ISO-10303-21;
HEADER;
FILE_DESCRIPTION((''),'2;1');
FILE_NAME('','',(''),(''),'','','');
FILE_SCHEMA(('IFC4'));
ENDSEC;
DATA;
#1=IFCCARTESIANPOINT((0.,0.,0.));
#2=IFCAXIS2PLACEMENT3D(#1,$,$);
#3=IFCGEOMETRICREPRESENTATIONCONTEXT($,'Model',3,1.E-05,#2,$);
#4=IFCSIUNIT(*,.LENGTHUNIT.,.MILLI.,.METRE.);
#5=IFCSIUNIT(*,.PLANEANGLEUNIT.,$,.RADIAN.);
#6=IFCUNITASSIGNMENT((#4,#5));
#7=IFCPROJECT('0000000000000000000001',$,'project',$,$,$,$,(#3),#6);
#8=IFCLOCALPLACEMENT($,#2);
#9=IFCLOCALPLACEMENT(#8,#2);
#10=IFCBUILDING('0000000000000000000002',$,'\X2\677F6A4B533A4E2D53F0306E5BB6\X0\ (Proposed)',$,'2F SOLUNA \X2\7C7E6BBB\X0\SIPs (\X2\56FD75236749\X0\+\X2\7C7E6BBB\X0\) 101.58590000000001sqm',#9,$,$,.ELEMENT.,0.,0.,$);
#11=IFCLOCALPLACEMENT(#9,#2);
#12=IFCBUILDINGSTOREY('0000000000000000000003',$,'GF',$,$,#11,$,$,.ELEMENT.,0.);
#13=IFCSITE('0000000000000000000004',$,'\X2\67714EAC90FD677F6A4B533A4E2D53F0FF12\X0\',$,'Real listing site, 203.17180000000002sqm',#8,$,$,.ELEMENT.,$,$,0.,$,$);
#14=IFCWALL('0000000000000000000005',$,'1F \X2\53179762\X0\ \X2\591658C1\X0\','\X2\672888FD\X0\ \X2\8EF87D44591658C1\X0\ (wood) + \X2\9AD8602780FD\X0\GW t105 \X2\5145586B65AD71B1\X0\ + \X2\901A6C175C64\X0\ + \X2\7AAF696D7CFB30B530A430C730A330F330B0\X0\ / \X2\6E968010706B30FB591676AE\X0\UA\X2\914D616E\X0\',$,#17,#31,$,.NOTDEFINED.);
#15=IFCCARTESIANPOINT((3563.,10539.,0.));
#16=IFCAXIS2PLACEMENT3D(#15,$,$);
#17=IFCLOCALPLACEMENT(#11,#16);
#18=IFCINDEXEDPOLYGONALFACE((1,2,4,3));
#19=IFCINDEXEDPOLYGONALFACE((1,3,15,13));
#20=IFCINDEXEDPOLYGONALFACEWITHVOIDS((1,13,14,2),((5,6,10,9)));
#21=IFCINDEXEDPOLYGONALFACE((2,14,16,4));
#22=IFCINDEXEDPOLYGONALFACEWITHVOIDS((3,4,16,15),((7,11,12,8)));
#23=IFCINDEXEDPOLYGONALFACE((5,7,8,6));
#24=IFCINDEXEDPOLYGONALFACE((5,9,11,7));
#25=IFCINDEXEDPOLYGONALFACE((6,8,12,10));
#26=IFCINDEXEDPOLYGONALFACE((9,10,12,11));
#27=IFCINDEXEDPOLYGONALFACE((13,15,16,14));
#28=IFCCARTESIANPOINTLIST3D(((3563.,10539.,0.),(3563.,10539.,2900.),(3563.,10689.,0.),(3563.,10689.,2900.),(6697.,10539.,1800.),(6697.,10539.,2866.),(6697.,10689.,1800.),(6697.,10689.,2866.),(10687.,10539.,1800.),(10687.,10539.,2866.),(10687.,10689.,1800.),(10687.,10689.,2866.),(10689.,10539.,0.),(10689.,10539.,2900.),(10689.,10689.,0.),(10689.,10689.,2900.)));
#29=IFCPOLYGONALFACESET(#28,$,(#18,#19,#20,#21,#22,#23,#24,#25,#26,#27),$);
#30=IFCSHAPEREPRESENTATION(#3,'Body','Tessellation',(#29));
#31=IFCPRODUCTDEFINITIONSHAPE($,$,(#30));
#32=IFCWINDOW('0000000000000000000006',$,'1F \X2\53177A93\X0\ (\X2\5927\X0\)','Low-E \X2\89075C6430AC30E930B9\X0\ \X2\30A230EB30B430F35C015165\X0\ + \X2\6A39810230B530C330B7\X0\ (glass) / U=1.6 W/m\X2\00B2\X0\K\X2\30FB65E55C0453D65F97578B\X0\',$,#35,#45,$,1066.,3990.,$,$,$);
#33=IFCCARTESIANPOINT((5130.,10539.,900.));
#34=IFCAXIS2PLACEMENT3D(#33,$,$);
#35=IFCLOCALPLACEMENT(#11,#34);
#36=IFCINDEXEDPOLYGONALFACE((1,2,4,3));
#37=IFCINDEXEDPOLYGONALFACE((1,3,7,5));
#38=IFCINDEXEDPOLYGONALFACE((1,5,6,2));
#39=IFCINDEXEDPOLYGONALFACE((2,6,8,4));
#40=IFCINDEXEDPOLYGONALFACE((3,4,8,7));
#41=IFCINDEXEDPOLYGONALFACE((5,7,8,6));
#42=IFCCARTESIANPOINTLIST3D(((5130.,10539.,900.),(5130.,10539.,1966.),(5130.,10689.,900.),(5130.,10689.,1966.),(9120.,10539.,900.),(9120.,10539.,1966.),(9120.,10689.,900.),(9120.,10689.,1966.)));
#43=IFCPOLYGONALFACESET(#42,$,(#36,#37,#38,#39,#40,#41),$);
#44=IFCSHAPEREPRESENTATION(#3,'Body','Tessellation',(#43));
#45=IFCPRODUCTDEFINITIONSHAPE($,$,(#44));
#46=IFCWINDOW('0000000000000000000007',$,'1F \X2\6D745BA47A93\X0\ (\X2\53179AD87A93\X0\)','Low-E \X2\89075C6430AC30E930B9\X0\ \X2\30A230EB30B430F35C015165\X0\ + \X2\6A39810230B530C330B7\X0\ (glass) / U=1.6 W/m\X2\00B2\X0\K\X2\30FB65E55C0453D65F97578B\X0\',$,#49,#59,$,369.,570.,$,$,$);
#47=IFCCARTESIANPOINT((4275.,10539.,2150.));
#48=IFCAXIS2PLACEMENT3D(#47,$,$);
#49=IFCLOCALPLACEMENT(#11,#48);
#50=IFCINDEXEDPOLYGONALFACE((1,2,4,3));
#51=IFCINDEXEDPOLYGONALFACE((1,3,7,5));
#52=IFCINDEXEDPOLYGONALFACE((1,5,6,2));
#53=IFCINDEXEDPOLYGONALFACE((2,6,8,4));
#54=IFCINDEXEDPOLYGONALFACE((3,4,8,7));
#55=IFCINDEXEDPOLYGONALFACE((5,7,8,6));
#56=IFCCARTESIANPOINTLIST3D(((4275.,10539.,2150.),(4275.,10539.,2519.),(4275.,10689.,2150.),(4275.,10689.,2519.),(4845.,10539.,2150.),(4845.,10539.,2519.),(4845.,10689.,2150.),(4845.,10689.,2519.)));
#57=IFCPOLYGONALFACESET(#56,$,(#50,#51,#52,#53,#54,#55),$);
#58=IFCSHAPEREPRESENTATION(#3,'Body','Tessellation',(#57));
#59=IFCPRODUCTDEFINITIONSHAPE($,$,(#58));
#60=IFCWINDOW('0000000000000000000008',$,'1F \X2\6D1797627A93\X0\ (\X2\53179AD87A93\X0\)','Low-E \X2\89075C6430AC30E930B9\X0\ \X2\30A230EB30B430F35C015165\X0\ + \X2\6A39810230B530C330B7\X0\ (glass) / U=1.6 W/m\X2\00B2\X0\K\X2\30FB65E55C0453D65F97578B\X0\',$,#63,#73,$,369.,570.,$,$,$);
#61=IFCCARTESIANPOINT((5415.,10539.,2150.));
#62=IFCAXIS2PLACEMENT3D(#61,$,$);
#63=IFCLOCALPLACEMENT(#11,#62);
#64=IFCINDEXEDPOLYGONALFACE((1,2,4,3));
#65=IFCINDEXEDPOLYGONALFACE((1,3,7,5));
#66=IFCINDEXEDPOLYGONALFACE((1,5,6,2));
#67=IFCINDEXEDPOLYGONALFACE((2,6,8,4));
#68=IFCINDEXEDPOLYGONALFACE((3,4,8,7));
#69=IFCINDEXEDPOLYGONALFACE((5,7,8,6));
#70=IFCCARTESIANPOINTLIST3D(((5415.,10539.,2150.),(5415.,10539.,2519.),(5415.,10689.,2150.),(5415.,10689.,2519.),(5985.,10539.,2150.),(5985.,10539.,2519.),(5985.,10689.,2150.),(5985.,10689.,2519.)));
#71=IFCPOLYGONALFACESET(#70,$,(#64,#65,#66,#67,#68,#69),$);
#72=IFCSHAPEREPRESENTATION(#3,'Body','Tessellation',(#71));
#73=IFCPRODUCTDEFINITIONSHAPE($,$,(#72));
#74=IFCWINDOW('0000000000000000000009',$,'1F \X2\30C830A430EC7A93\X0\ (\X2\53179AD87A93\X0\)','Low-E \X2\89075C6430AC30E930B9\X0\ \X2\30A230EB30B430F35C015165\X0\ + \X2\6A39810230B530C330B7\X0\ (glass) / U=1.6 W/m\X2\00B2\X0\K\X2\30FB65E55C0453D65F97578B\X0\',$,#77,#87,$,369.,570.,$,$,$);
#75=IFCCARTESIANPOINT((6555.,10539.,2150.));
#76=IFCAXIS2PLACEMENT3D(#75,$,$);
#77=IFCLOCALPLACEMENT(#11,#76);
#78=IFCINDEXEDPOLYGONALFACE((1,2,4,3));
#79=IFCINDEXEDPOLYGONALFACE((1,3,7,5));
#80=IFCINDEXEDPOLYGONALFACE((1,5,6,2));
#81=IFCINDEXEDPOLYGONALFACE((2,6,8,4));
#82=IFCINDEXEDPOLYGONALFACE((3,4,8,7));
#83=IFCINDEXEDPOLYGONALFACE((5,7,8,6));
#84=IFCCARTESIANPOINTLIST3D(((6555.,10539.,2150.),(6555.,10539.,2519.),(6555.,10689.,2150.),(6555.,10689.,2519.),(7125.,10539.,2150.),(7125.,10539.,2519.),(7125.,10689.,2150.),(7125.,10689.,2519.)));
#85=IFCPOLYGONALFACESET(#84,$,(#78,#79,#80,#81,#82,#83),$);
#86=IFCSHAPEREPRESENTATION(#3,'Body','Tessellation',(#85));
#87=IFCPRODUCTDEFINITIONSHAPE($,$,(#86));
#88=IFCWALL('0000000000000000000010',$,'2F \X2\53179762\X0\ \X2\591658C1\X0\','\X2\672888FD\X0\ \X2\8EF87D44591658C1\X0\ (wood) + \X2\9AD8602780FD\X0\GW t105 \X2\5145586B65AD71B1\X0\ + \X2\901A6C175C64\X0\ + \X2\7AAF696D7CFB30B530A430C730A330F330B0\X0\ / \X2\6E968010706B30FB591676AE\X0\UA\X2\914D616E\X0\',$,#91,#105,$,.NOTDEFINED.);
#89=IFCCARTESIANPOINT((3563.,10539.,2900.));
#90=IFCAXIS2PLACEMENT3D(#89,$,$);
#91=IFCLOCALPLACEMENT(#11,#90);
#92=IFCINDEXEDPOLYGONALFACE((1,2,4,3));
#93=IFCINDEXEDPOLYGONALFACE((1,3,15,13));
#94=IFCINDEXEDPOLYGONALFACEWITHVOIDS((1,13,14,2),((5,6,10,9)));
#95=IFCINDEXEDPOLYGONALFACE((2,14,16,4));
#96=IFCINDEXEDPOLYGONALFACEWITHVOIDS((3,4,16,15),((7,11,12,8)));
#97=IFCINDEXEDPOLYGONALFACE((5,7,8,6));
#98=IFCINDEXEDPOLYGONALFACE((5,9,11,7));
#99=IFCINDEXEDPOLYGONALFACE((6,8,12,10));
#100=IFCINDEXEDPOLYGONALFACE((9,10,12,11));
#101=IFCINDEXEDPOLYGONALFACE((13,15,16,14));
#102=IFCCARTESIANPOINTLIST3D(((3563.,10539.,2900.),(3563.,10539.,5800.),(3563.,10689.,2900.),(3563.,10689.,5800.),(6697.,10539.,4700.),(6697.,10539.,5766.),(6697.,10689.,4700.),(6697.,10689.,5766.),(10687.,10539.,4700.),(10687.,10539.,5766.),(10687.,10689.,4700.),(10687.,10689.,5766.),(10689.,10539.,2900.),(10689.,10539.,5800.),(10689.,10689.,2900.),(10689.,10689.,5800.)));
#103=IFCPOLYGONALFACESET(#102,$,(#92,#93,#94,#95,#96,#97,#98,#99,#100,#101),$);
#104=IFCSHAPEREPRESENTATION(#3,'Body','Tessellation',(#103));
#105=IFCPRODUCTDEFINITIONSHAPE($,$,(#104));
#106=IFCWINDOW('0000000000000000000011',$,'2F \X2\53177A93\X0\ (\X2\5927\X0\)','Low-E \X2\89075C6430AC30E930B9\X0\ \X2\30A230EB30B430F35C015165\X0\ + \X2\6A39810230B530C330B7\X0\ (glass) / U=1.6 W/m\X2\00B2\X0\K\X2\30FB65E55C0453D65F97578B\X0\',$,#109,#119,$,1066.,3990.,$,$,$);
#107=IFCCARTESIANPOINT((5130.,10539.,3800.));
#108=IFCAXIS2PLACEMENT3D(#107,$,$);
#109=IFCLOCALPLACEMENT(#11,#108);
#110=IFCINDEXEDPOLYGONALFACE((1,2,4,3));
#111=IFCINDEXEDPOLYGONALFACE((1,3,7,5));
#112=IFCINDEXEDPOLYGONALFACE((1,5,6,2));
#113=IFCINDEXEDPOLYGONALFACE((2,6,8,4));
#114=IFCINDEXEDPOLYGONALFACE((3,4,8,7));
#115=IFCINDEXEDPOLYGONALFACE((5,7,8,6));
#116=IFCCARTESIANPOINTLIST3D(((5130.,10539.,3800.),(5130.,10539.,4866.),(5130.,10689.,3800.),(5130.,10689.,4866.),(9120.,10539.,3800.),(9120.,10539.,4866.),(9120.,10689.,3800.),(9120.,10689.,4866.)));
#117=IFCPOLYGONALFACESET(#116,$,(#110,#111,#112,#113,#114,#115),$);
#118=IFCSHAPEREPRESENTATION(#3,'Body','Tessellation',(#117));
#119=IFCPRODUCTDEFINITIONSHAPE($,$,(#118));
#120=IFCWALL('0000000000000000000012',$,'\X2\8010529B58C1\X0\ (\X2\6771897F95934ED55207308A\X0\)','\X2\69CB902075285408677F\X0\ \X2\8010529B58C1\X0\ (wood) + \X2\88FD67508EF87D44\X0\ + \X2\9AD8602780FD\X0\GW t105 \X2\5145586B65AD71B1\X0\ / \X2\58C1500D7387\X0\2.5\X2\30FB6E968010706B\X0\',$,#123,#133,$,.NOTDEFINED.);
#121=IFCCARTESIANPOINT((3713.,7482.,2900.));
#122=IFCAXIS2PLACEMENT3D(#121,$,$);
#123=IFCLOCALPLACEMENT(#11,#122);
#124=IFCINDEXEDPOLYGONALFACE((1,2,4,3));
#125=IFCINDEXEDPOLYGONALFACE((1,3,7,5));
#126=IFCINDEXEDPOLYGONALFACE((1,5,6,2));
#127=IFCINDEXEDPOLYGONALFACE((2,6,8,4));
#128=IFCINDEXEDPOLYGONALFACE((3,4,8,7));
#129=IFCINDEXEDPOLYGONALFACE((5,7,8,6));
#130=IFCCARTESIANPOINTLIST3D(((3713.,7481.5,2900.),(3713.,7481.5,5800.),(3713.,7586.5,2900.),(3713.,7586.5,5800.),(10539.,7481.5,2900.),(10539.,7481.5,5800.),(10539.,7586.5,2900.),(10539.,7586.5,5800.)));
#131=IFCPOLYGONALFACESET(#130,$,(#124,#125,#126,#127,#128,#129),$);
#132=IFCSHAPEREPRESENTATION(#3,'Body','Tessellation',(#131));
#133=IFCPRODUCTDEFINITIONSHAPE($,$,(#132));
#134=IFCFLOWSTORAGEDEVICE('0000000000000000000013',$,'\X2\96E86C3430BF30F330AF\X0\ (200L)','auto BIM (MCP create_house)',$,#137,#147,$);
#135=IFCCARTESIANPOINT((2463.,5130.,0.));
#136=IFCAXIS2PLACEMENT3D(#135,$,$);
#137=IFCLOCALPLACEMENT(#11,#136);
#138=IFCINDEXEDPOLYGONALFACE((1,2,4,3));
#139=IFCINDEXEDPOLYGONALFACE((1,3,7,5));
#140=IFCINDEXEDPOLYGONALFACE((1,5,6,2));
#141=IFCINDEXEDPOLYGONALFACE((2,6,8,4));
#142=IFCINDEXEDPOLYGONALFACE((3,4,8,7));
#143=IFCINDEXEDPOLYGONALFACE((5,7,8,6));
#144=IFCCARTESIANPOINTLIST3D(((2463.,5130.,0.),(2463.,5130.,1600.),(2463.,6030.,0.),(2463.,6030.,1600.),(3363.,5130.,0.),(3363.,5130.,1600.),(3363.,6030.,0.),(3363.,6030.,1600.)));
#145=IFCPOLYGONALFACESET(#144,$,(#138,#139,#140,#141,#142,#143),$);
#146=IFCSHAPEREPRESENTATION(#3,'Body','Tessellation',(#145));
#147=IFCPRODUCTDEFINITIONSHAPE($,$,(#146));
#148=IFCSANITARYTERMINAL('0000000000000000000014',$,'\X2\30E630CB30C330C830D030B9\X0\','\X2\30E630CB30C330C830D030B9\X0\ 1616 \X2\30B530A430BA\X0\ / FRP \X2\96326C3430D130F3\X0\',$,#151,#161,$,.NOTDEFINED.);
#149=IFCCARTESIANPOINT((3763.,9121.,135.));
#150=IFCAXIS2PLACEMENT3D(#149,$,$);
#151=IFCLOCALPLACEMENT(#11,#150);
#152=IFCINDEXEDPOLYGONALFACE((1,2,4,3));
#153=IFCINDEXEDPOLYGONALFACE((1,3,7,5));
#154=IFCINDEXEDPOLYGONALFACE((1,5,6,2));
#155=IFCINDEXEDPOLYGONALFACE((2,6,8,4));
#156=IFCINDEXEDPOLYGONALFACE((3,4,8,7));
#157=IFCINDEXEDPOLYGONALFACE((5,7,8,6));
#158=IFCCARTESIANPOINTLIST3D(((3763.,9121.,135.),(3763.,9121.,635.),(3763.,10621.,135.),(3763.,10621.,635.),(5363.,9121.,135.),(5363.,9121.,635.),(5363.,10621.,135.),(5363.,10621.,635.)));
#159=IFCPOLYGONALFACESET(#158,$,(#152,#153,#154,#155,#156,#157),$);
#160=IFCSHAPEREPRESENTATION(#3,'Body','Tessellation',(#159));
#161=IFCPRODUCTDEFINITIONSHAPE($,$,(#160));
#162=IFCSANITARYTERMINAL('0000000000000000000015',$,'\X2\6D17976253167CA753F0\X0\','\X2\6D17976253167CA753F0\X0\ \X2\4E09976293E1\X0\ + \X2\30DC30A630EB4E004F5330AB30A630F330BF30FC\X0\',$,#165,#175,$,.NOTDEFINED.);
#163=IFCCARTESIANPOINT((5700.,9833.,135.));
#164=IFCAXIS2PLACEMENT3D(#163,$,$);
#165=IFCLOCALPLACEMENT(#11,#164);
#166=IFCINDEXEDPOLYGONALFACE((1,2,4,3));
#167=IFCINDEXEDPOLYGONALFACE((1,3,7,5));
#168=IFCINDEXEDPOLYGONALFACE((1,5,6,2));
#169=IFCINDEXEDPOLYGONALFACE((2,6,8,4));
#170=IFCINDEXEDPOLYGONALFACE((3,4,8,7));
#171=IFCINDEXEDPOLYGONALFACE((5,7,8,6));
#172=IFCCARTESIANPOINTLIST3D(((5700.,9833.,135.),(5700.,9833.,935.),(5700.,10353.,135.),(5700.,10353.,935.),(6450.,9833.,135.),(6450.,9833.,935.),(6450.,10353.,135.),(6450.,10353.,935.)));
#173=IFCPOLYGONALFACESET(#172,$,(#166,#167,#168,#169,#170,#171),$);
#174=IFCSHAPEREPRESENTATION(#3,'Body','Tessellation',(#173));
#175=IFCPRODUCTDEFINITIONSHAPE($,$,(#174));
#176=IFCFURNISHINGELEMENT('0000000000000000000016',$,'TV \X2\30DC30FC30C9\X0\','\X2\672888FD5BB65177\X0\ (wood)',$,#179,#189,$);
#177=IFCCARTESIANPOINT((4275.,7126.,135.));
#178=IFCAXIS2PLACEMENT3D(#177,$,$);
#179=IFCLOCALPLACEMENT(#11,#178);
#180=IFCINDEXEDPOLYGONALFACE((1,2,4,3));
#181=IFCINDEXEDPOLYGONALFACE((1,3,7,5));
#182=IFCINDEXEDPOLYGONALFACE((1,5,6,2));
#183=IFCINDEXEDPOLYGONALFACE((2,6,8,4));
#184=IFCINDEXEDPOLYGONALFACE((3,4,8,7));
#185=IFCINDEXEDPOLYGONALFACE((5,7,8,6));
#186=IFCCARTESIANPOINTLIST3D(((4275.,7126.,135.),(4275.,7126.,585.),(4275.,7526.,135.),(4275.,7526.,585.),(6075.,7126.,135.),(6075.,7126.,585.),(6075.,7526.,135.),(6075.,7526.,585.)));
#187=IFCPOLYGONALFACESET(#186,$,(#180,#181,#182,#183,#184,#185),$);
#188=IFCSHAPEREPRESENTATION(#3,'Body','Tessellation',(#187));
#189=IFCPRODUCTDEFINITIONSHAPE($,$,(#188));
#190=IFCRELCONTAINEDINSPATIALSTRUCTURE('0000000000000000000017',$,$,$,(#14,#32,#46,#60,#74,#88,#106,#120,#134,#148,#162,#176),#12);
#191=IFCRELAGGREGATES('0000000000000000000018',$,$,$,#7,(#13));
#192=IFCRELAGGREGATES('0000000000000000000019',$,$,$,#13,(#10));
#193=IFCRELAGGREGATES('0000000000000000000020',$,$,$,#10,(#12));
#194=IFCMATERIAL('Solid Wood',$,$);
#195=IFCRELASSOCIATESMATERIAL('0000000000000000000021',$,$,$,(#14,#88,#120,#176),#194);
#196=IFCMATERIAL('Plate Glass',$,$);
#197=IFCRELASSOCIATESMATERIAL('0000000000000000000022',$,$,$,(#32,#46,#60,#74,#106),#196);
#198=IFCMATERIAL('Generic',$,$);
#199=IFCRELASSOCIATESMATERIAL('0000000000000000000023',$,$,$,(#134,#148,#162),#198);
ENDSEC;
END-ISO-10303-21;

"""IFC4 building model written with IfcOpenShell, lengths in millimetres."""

from ifc_helpers import new_model, si_unit, frame, frame_2d, origin, place, context, project, spatial, rectangle, extrude, material, element, fill, save


model = new_model("IFC4")

# Units and contexts
model_context = context("Model", 3, precision=1e-05, world=origin())
ifc_project = project(units=[si_unit("LENGTHUNIT", "METRE", prefix="MILLI"), si_unit("PLANEANGLEUNIT", "RADIAN")], contexts=[model_context])

# Site, building, storey
site_placement = place(None, origin())
site = spatial("IfcSite", under=ifc_project, at=site_placement, Name="東京都板橋区中台２", ObjectType="Real listing site, 203.17180000000002sqm", CompositionType="ELEMENT", RefElevation=0.0)
building_placement = place(site_placement, origin())
building = spatial("IfcBuilding", under=site, at=building_placement, Name="板橋区中台の家 (Proposed)", ObjectType="2F SOLUNA 籾殻SIPs (国産杉+籾殻) 101.58590000000001sqm", CompositionType="ELEMENT", ElevationOfRefHeight=0.0, ElevationOfTerrain=0.0)
storey_placement = place(building_placement, origin())
storey = spatial("IfcBuildingStorey", under=building, at=storey_placement, Name="GF", CompositionType="ELEMENT", Elevation=0.0)

# Wall, openings, windows
ifc_material_1 = material(Name="Solid Wood")
wall_1_placement = place(storey_placement, frame((3563.0, 10539.0, 0.0)))
wall_1 = element("IfcWall", 1, at=wall_1_placement, inside=storey, material=ifc_material_1, Name="1F 北面 外壁", Description="木製 軸組外壁 (wood) + 高性能GW t105 充填断熱 + 通気層 + 窯業系サイディング / 準耐火・外皮UA配慮", PredefinedType="NOTDEFINED", context=model_context, shape_type="SweptSolid", body=[
    extrude(rectangle(XDim=7126.0, YDim=150.0, at=frame_2d((3563.0, 75.0))), frame((3563.0, 10539.0, 0.0)), (0.0, 0.0, 1.0), 2900.0),
])
opening_1_placement = place(storey_placement, frame((5130.0, 10539.0, 900.0)))
opening_1 = element("IfcOpeningElement", 2, at=opening_1_placement, cuts=wall_1, PredefinedType="NOTDEFINED", context=model_context, shape_type="SweptSolid", body=[
    extrude(rectangle(XDim=3990.0, YDim=150.0, at=frame_2d((1995.0, 75.0))), frame((5130.0, 10539.0, 900.0)), (0.0, 0.0, 1.0), 1066.0),
])
opening_2_placement = place(storey_placement, frame((4275.0, 10539.0, 2150.0)))
opening_2 = element("IfcOpeningElement", 3, at=opening_2_placement, cuts=wall_1, PredefinedType="NOTDEFINED", context=model_context, shape_type="SweptSolid", body=[
    extrude(rectangle(XDim=570.0, YDim=150.0, at=frame_2d((285.0, 75.0))), frame((4275.0, 10539.0, 2150.0)), (0.0, 0.0, 1.0), 369.0),
])
opening_3_placement = place(storey_placement, frame((5415.0, 10539.0, 2150.0)))
opening_3 = element("IfcOpeningElement", 4, at=opening_3_placement, cuts=wall_1, PredefinedType="NOTDEFINED", context=model_context, shape_type="SweptSolid", body=[
    extrude(rectangle(XDim=570.0, YDim=150.0, at=frame_2d((285.0, 75.0))), frame((5415.0, 10539.0, 2150.0)), (0.0, 0.0, 1.0), 369.0),
])
opening_4_placement = place(storey_placement, frame((6555.0, 10539.0, 2150.0)))
opening_4 = element("IfcOpeningElement", 5, at=opening_4_placement, cuts=wall_1, PredefinedType="NOTDEFINED", context=model_context, shape_type="SweptSolid", body=[
    extrude(rectangle(XDim=570.0, YDim=150.0, at=frame_2d((285.0, 75.0))), frame((6555.0, 10539.0, 2150.0)), (0.0, 0.0, 1.0), 369.0),
])
ifc_material_2 = material(Name="Plate Glass")
window_1_placement = place(storey_placement, frame((5130.0, 10539.0, 900.0)))
window_1 = element("IfcWindow", 6, at=window_1_placement, inside=storey, material=ifc_material_2, Name="1F 北窓 (大)", Description="Low-E 複層ガラス アルゴン封入 + 樹脂サッシ (glass) / U=1.6 W/m²K・日射取得型", OverallHeight=1066.0, OverallWidth=3990.0, context=model_context, shape_type="SweptSolid", body=[
    extrude(rectangle(XDim=3990.0, YDim=150.0, at=frame_2d((1995.0, 75.0))), frame((5130.0, 10539.0, 900.0)), (0.0, 0.0, 1.0), 1066.0),
])
fill(opening_1, window_1)
window_2_placement = place(storey_placement, frame((4275.0, 10539.0, 2150.0)))
window_2 = element("IfcWindow", 7, at=window_2_placement, inside=storey, material=ifc_material_2, Name="1F 浴室窓 (北高窓)", Description="Low-E 複層ガラス アルゴン封入 + 樹脂サッシ (glass) / U=1.6 W/m²K・日射取得型", OverallHeight=369.0, OverallWidth=570.0, context=model_context, shape_type="SweptSolid", body=[
    extrude(rectangle(XDim=570.0, YDim=150.0, at=frame_2d((285.0, 75.0))), frame((4275.0, 10539.0, 2150.0)), (0.0, 0.0, 1.0), 369.0),
])
fill(opening_2, window_2)
window_3_placement = place(storey_placement, frame((5415.0, 10539.0, 2150.0)))
window_3 = element("IfcWindow", 8, at=window_3_placement, inside=storey, material=ifc_material_2, Name="1F 洗面窓 (北高窓)", Description="Low-E 複層ガラス アルゴン封入 + 樹脂サッシ (glass) / U=1.6 W/m²K・日射取得型", OverallHeight=369.0, OverallWidth=570.0, context=model_context, shape_type="SweptSolid", body=[
    extrude(rectangle(XDim=570.0, YDim=150.0, at=frame_2d((285.0, 75.0))), frame((5415.0, 10539.0, 2150.0)), (0.0, 0.0, 1.0), 369.0),
])
fill(opening_3, window_3)
window_4_placement = place(storey_placement, frame((6555.0, 10539.0, 2150.0)))
window_4 = element("IfcWindow", 9, at=window_4_placement, inside=storey, material=ifc_material_2, Name="1F トイレ窓 (北高窓)", Description="Low-E 複層ガラス アルゴン封入 + 樹脂サッシ (glass) / U=1.6 W/m²K・日射取得型", OverallHeight=369.0, OverallWidth=570.0, context=model_context, shape_type="SweptSolid", body=[
    extrude(rectangle(XDim=570.0, YDim=150.0, at=frame_2d((285.0, 75.0))), frame((6555.0, 10539.0, 2150.0)), (0.0, 0.0, 1.0), 369.0),
])
fill(opening_4, window_4)

# Wall, opening, window
wall_2_placement = place(storey_placement, frame((3563.0, 10539.0, 2900.0)))
wall_2 = element("IfcWall", 10, at=wall_2_placement, inside=storey, material=ifc_material_1, Name="2F 北面 外壁", Description="木製 軸組外壁 (wood) + 高性能GW t105 充填断熱 + 通気層 + 窯業系サイディング / 準耐火・外皮UA配慮", PredefinedType="NOTDEFINED", context=model_context, shape_type="SweptSolid", body=[
    extrude(rectangle(XDim=7126.0, YDim=150.0, at=frame_2d((3563.0, 75.0))), frame((3563.0, 10539.0, 2900.0)), (0.0, 0.0, 1.0), 2900.0),
])
opening_5_placement = place(storey_placement, frame((5130.0, 10539.0, 3800.0)))
opening_5 = element("IfcOpeningElement", 11, at=opening_5_placement, cuts=wall_2, PredefinedType="NOTDEFINED", context=model_context, shape_type="SweptSolid", body=[
    extrude(rectangle(XDim=3990.0, YDim=150.0, at=frame_2d((1995.0, 75.0))), frame((5130.0, 10539.0, 3800.0)), (0.0, 0.0, 1.0), 1066.0),
])
window_5_placement = place(storey_placement, frame((5130.0, 10539.0, 3800.0)))
window_5 = element("IfcWindow", 12, at=window_5_placement, inside=storey, material=ifc_material_2, Name="2F 北窓 (大)", Description="Low-E 複層ガラス アルゴン封入 + 樹脂サッシ (glass) / U=1.6 W/m²K・日射取得型", OverallHeight=1066.0, OverallWidth=3990.0, context=model_context, shape_type="SweptSolid", body=[
    extrude(rectangle(XDim=3990.0, YDim=150.0, at=frame_2d((1995.0, 75.0))), frame((5130.0, 10539.0, 3800.0)), (0.0, 0.0, 1.0), 1066.0),
])
fill(opening_5, window_5)

# Wall
wall_3_placement = place(storey_placement, frame((3713.0, 7482.0, 2900.0)))
element("IfcWall", 13, at=wall_3_placement, inside=storey, material=ifc_material_1, Name="耐力壁 (東西間仕切り)", Description="構造用合板 耐力壁 (wood) + 製材軸組 + 高性能GW t105 充填断熱 / 壁倍率2.5・準耐火", PredefinedType="NOTDEFINED", context=model_context, shape_type="SweptSolid", body=[
    extrude(rectangle(XDim=6826.0, YDim=105.0, at=frame_2d((3413.0, 52.0))), frame((3713.0, 7482.0, 2900.0)), (0.0, 0.0, 1.0), 2900.0),
])

# Flow storage device
ifc_material_3 = material(Name="Generic")
flow_storage_device_placement = place(storey_placement, frame((2463.0, 5130.0, 0.0)))
element("IfcFlowStorageDevice", 14, at=flow_storage_device_placement, inside=storey, material=ifc_material_3, Name="雨水タンク (200L)", Description="auto BIM (MCP create_house)", context=model_context, shape_type="SweptSolid", body=[
    extrude(rectangle(XDim=900.0, YDim=900.0, at=frame_2d((450.0, 450.0))), frame((2463.0, 5130.0, 0.0)), (0.0, 0.0, 1.0), 1600.0),
])

# Sanitary terminals
sanitary_terminal_1_placement = place(storey_placement, frame((3763.0, 9121.0, 135.0)))
element("IfcSanitaryTerminal", 15, at=sanitary_terminal_1_placement, inside=storey, material=ifc_material_3, Name="ユニットバス", Description="ユニットバス 1616 サイズ / FRP 防水パン", PredefinedType="NOTDEFINED", context=model_context, shape_type="SweptSolid", body=[
    extrude(rectangle(XDim=1600.0, YDim=1500.0, at=frame_2d((800.0, 750.0))), frame((3763.0, 9121.0, 135.0)), (0.0, 0.0, 1.0), 500.0),
])
sanitary_terminal_2_placement = place(storey_placement, frame((5700.0, 9833.0, 135.0)))
element("IfcSanitaryTerminal", 16, at=sanitary_terminal_2_placement, inside=storey, material=ifc_material_3, Name="洗面化粧台", Description="洗面化粧台 三面鏡 + ボウル一体カウンター", PredefinedType="NOTDEFINED", context=model_context, shape_type="SweptSolid", body=[
    extrude(rectangle(XDim=750.0, YDim=520.0, at=frame_2d((375.0, 260.0))), frame((5700.0, 9833.0, 135.0)), (0.0, 0.0, 1.0), 800.0),
])

# Furnishing element
furnishing_1_placement = place(storey_placement, frame((4275.0, 7126.0, 135.0)))
element("IfcFurnishingElement", 17, at=furnishing_1_placement, inside=storey, material=ifc_material_1, Name="TV ボード", Description="木製家具 (wood)", context=model_context, shape_type="SweptSolid", body=[
    extrude(rectangle(XDim=1800.0, YDim=400.0, at=frame_2d((900.0, 200.0))), frame((4275.0, 7126.0, 135.0)), (0.0, 0.0, 1.0), 450.0),
])

save(model, "model.ifc")
